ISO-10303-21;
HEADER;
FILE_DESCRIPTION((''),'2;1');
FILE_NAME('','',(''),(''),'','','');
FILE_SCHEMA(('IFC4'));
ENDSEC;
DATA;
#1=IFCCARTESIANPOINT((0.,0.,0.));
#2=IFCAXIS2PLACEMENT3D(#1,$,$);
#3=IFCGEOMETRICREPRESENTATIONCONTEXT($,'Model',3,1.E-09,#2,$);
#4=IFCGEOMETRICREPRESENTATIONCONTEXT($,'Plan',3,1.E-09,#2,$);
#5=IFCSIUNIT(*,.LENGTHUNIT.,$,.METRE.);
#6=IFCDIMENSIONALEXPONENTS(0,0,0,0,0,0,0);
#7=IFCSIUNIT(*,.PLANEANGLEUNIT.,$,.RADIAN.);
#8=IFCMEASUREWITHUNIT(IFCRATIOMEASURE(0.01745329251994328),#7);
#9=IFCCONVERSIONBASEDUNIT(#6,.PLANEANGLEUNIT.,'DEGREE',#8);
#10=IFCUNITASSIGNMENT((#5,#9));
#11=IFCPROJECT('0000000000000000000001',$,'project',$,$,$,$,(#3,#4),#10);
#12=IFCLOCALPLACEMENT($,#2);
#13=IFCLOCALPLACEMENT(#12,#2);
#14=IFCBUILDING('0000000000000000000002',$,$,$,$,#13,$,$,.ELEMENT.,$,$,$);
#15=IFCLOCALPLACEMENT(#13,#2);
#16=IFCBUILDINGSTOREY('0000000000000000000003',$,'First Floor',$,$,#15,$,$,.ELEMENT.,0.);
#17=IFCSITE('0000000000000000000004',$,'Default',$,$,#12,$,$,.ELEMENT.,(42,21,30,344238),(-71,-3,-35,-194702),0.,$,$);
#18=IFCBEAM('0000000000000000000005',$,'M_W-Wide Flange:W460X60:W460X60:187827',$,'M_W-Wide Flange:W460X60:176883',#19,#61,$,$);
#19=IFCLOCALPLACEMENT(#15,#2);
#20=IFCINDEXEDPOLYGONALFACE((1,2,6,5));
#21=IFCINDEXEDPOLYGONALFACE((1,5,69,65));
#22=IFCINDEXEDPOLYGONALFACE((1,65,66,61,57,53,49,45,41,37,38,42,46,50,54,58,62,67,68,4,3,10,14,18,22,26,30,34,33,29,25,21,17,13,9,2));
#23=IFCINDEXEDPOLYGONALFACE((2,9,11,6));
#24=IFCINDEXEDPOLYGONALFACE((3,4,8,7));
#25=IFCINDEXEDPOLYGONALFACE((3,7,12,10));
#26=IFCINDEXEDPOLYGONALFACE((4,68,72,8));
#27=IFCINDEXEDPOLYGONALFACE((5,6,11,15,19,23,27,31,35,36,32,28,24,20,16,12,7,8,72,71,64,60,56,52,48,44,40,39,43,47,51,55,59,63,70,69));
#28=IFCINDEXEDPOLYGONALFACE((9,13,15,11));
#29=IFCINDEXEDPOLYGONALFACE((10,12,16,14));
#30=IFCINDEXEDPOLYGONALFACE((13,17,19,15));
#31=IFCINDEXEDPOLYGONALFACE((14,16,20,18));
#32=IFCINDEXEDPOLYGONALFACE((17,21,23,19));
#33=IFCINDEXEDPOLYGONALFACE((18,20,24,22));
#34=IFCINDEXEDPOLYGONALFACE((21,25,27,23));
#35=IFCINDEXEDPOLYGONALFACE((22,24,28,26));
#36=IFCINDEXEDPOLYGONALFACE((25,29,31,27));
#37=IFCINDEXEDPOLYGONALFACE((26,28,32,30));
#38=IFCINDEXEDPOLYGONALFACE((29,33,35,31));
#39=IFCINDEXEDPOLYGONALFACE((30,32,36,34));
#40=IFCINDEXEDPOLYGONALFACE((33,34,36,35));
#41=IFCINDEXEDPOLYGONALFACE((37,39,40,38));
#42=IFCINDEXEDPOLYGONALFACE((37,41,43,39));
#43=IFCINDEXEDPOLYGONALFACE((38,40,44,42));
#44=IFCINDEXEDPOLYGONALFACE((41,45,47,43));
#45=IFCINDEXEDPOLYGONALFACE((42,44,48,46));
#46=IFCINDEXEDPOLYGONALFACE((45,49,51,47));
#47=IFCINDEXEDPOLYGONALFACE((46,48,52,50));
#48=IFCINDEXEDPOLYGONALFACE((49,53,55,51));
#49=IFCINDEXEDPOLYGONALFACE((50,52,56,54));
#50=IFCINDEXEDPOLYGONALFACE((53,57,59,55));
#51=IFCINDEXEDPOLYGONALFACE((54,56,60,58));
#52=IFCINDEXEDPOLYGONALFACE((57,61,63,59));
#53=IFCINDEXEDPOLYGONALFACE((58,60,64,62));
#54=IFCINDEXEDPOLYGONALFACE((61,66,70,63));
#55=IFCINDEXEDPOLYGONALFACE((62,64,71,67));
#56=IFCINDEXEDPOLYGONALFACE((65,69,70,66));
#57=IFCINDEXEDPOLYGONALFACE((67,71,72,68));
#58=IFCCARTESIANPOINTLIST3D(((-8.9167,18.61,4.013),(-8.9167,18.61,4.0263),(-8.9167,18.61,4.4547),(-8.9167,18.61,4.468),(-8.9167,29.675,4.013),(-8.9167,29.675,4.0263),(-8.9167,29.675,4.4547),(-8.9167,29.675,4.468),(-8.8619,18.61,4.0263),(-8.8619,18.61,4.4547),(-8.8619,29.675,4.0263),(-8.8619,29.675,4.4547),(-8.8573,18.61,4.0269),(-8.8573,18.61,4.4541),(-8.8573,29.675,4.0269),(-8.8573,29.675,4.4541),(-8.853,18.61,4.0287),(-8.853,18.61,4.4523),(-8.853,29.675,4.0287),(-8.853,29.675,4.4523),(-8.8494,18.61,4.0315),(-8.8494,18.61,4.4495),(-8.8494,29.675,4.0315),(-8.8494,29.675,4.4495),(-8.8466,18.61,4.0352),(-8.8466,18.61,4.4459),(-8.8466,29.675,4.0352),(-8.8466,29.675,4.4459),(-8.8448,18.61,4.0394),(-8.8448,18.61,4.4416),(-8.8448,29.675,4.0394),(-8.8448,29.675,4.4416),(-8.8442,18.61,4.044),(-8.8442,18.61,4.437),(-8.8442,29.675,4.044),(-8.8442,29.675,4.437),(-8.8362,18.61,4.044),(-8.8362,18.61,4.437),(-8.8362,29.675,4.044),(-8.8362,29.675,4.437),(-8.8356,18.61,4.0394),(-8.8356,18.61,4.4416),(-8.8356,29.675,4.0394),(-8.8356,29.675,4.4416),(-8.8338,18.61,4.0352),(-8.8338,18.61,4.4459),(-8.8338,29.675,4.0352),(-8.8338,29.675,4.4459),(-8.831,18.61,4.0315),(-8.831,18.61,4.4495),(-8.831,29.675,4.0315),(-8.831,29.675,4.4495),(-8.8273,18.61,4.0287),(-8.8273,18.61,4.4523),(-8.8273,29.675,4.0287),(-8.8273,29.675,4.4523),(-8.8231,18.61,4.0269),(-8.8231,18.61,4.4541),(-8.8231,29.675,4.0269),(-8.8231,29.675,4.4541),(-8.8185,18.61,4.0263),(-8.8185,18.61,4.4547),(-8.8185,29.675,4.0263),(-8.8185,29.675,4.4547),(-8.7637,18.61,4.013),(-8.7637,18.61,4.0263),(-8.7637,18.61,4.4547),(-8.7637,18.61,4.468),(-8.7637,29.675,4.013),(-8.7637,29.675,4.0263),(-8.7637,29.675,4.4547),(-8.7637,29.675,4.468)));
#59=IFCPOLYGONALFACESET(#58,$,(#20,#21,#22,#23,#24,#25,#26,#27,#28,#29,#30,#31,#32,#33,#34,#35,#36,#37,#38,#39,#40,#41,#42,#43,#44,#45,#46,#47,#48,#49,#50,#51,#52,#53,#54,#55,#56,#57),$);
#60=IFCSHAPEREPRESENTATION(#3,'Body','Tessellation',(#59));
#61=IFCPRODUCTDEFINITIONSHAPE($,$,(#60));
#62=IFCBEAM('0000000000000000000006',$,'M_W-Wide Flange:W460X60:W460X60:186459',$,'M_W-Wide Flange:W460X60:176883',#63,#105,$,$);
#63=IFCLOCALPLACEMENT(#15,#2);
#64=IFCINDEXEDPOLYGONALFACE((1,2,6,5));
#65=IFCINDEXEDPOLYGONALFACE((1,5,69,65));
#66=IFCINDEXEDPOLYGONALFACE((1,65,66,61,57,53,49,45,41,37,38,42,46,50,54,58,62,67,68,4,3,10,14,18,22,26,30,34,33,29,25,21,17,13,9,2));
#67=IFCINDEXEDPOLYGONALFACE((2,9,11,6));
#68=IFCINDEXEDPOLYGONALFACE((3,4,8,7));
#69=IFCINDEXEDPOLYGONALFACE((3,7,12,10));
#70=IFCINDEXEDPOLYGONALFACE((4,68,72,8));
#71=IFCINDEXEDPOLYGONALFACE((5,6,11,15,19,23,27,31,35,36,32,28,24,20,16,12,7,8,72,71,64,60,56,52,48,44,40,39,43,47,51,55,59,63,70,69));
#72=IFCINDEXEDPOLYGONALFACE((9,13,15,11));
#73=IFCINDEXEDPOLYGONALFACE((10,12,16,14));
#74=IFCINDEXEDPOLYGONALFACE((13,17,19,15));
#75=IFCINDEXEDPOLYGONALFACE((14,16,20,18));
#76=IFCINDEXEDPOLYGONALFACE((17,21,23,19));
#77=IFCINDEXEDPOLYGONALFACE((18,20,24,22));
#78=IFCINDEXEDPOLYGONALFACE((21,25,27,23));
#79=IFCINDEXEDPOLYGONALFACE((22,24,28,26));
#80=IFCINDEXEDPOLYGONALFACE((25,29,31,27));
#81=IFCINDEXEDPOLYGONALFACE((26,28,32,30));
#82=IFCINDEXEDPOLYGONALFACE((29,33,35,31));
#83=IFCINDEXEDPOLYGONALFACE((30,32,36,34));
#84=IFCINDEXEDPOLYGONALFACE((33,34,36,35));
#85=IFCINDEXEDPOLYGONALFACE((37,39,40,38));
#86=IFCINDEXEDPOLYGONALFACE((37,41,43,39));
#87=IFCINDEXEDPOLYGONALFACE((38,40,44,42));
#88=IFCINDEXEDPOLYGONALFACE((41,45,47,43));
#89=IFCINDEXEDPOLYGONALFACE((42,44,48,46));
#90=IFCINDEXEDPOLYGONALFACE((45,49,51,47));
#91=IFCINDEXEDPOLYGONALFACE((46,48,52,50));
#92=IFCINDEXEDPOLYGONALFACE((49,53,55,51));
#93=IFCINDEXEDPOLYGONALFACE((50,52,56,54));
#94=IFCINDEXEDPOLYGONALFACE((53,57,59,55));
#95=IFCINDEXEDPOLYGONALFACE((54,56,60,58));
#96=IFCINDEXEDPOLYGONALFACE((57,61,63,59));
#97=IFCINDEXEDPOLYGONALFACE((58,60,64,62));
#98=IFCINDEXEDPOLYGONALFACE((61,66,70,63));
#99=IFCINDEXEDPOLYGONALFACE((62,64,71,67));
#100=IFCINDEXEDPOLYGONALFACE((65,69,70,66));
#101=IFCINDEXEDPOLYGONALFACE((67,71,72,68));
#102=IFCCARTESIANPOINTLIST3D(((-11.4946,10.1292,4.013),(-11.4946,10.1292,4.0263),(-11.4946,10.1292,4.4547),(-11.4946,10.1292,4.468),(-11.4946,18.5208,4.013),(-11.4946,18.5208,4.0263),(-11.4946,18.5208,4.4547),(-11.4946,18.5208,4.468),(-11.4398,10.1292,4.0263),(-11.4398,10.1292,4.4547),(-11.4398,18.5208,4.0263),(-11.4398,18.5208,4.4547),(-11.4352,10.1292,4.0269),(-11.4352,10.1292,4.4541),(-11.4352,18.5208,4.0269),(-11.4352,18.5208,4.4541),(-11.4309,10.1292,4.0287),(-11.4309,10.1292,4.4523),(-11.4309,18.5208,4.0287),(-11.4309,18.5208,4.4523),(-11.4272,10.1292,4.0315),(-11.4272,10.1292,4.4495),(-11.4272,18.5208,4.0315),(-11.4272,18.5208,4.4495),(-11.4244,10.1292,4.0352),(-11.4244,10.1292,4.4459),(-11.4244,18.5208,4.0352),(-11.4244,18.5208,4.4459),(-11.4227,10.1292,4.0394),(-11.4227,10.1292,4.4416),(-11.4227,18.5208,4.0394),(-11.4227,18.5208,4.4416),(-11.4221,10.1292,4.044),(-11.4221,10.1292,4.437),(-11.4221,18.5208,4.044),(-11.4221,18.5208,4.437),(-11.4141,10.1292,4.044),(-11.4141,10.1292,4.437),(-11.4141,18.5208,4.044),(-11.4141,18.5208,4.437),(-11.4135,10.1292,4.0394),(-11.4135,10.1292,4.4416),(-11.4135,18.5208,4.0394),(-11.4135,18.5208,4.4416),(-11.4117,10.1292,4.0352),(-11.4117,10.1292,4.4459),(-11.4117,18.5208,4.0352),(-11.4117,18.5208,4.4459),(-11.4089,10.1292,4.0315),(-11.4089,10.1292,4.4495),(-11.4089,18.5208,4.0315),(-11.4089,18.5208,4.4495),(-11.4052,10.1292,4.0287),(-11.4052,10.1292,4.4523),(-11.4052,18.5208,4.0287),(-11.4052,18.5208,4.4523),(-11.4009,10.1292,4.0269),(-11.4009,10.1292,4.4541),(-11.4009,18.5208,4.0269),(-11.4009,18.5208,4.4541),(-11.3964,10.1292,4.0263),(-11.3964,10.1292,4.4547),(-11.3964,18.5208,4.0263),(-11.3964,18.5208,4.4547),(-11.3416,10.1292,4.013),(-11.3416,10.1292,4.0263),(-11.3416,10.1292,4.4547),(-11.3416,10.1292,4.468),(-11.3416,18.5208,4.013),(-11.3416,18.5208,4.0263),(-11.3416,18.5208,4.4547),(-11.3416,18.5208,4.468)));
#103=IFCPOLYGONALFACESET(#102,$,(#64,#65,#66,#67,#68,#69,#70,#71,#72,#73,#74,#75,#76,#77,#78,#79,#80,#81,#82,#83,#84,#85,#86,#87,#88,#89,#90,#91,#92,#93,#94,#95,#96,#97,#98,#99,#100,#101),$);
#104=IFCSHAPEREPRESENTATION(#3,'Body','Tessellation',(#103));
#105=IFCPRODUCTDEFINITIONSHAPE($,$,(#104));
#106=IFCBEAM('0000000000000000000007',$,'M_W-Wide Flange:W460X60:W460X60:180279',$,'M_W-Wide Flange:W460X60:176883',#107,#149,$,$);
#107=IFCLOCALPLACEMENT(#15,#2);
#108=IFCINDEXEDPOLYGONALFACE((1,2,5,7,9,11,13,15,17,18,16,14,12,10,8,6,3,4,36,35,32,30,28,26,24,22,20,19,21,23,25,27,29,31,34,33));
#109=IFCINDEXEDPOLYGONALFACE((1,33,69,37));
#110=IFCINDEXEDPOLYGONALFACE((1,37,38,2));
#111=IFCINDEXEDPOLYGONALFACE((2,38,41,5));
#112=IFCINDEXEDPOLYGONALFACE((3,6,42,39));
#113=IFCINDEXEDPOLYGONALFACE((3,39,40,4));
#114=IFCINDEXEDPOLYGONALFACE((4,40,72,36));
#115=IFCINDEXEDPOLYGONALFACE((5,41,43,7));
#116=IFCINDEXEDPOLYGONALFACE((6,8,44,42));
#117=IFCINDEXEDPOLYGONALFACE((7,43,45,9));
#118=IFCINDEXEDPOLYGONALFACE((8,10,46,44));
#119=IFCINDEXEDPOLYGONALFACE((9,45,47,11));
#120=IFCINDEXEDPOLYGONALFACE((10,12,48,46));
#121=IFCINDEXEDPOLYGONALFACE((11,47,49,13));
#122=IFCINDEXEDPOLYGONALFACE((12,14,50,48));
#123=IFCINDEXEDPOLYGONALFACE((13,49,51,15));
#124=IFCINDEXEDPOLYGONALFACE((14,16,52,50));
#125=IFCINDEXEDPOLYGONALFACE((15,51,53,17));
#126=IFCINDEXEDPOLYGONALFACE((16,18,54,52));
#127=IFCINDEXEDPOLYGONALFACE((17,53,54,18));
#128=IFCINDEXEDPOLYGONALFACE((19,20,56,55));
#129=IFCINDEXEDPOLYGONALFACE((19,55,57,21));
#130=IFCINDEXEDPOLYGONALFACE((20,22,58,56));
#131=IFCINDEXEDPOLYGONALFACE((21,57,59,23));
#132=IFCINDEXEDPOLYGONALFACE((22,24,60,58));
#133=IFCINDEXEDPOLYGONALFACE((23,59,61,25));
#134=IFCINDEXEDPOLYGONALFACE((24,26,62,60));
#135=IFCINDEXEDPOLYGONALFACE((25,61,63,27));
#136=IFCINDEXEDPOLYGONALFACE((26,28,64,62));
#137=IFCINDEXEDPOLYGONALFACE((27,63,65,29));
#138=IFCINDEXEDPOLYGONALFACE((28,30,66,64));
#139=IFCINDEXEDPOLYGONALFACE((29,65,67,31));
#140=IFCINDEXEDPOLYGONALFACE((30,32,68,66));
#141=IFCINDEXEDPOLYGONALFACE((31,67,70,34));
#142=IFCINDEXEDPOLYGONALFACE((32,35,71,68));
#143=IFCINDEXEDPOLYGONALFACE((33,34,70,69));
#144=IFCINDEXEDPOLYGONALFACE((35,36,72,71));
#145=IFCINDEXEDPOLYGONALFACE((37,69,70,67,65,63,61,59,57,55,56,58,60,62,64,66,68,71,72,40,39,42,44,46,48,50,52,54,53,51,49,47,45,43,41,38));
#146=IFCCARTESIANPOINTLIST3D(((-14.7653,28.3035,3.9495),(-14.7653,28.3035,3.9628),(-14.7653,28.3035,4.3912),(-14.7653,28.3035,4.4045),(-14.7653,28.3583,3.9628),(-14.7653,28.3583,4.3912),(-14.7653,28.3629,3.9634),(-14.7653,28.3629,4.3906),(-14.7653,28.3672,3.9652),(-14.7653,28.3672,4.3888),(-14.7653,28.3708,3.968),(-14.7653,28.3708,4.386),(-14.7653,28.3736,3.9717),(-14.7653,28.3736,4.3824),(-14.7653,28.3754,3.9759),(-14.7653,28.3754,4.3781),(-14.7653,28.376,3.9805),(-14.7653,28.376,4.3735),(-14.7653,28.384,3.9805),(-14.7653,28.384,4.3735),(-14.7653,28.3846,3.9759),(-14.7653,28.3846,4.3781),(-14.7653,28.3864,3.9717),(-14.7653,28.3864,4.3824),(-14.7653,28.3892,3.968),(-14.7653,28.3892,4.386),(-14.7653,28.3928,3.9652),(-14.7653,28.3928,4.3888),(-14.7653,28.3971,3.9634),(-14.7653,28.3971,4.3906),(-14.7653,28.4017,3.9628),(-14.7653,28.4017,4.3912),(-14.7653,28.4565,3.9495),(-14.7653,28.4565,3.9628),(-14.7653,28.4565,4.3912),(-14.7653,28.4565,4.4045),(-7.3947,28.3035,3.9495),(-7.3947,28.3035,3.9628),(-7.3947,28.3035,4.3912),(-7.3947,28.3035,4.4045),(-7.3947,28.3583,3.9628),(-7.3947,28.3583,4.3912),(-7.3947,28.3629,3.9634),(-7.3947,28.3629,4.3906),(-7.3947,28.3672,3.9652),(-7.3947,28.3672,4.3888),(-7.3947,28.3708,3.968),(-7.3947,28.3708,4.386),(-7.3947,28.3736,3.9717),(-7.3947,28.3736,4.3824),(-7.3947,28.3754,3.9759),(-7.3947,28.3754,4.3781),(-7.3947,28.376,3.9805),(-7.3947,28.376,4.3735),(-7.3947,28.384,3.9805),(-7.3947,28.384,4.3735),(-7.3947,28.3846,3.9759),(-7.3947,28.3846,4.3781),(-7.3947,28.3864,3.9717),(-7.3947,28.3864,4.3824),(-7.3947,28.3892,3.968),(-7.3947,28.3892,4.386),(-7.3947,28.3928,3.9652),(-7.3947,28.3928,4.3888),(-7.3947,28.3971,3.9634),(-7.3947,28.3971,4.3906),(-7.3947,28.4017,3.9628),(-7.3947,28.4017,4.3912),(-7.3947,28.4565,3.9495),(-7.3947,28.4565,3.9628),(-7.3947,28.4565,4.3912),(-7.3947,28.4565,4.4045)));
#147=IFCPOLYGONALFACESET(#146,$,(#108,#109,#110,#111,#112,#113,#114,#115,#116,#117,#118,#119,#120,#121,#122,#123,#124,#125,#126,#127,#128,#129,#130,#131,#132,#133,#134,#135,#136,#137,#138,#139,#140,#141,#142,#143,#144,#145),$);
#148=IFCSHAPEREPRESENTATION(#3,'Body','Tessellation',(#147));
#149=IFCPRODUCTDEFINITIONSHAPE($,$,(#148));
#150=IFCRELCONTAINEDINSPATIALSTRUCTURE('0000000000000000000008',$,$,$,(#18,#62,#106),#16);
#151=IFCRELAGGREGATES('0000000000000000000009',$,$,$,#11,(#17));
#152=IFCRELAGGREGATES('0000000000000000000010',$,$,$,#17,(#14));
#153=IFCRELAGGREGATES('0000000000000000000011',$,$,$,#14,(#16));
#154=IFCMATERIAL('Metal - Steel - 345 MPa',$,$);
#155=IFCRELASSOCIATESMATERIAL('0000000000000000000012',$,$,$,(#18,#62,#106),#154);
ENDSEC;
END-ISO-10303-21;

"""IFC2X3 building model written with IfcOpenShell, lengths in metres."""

from ifc_helpers import new_model, entity, si_unit, converted_unit, frame, frame_2d, origin, place, context, project, spatial, polyline, circle_curve, parameter, trimmed, segment, composite_curve, outline, extrude, material, element, save


model = new_model("IFC2X3")

# Units and contexts
model_context = context("Model", 3, precision=1e-09, world=origin())
plan_context = context("Plan", 3, precision=1e-09, world=origin())
ifc_project = project(units=[si_unit("LENGTHUNIT", "METRE"), converted_unit("PLANEANGLEUNIT", "DEGREE", entity("IfcRatioMeasure", 0.01745329251994328), si_unit("PLANEANGLEUNIT", "RADIAN"), dimensions=[0, 0, 0, 0, 0, 0, 0])], contexts=[model_context, plan_context])

# Site, building, storey
site_placement = place(None, origin())
site = spatial("IfcSite", under=ifc_project, at=site_placement, Name="Default", CompositionType="ELEMENT", RefLatitude=(42, 21, 30, 344238), RefLongitude=(-71, -3, -35, -194702), RefElevation=0.0)
building_placement = place(site_placement, origin())
building = spatial("IfcBuilding", under=site, at=building_placement, CompositionType="ELEMENT")
storey_placement = place(building_placement, origin())
storey = spatial("IfcBuildingStorey", under=building, at=storey_placement, Name="First Floor", CompositionType="ELEMENT", Elevation=0.0)

# Shared definitions
ifc_material = material(Name="Metal - Steel - 345 MPa")

# Beams
beam_1_placement = place(storey_placement, frame((-8.8402, 18.7626, 4.468)))
element("IfcBeam", 1, at=beam_1_placement, inside=storey, material=ifc_material, Name="M_W-Wide Flange:W460X60:W460X60:187827", ObjectType="M_W-Wide Flange:W460X60:176883", context=model_context, shape_type="SweptSolid", body=[
    extrude(outline(composite_curve([segment(polyline([(-0.0765, -0.2142), (-0.0765, -0.2275)]), True, "CONTINUOUS"), segment(polyline([(-0.0765, -0.2275), (0.0765, -0.2275)]), True, "CONTINUOUS"), segment(polyline([(0.0765, -0.2275), (0.0765, -0.2142)]), True, "CONTINUOUS"), segment(polyline([(0.0765, -0.2142), (0.0217, -0.2142)]), True, "CONTINUOUS"), segment(trimmed(circle_curve(frame_2d((0.0217, -0.1965), x_axis=(1.0, 0.0)), 0.0177), [parameter(180.0)], [parameter(270.0)], True, "PARAMETER"), False, "CONTINUOUS"), segment(polyline([(0.004, -0.1965), (0.004, 0.1965)]), True, "CONTINUOUS"), segment(trimmed(circle_curve(frame_2d((0.0217, 0.1965), x_axis=(1.0, 0.0)), 0.0177), [parameter(90.0)], [parameter(180.0)], True, "PARAMETER"), False, "CONTINUOUS"), segment(polyline([(0.0217, 0.2142), (0.0765, 0.2142)]), True, "CONTINUOUS"), segment(polyline([(0.0765, 0.2142), (0.0765, 0.2275)]), True, "CONTINUOUS"), segment(polyline([(0.0765, 0.2275), (-0.0765, 0.2275)]), True, "CONTINUOUS"), segment(polyline([(-0.0765, 0.2275), (-0.0765, 0.2142)]), True, "CONTINUOUS"), segment(polyline([(-0.0765, 0.2142), (-0.0217, 0.2142)]), True, "CONTINUOUS"), segment(trimmed(circle_curve(frame_2d((-0.0217, 0.1965), x_axis=(1.0, 0.0)), 0.0177), [parameter(360.0)], [parameter(90.0)], True, "PARAMETER"), False, "CONTINUOUS"), segment(polyline([(-0.004, 0.1965), (-0.004, -0.1965)]), True, "CONTINUOUS"), segment(trimmed(circle_curve(frame_2d((-0.0217, -0.1965), x_axis=(1.0, 0.0)), 0.0177), [parameter(270.0)], [parameter(0.0)], True, "PARAMETER"), False, "CONTINUOUS"), segment(polyline([(-0.0217, -0.2142), (-0.0765, -0.2142)]), True, "CONTINUOUS")], self_intersect=False)), frame((0.0, -0.1526, -0.2275), z_axis=(0.0, -1.0, 0.0), x_axis=(1.0, 0.0, 0.0)), (0.0, 0.0, -1.0), 11.065),
])
beam_2_placement = place(storey_placement, frame((-11.4181, 10.1909, 4.468)))
element("IfcBeam", 2, at=beam_2_placement, inside=storey, material=ifc_material, Name="M_W-Wide Flange:W460X60:W460X60:186459", ObjectType="M_W-Wide Flange:W460X60:176883", context=model_context, shape_type="SweptSolid", body=[
    extrude(outline(composite_curve([segment(polyline([(-0.0765, -0.2142), (-0.0765, -0.2275)]), True, "CONTINUOUS"), segment(polyline([(-0.0765, -0.2275), (0.0765, -0.2275)]), True, "CONTINUOUS"), segment(polyline([(0.0765, -0.2275), (0.0765, -0.2142)]), True, "CONTINUOUS"), segment(polyline([(0.0765, -0.2142), (0.0217, -0.2142)]), True, "CONTINUOUS"), segment(trimmed(circle_curve(frame_2d((0.0217, -0.1965), x_axis=(1.0, 0.0)), 0.0177), [parameter(180.0)], [parameter(270.0)], True, "PARAMETER"), False, "CONTINUOUS"), segment(polyline([(0.004, -0.1965), (0.004, 0.1965)]), True, "CONTINUOUS"), segment(trimmed(circle_curve(frame_2d((0.0217, 0.1965), x_axis=(1.0, 0.0)), 0.0177), [parameter(90.0)], [parameter(180.0)], True, "PARAMETER"), False, "CONTINUOUS"), segment(polyline([(0.0217, 0.2142), (0.0765, 0.2142)]), True, "CONTINUOUS"), segment(polyline([(0.0765, 0.2142), (0.0765, 0.2275)]), True, "CONTINUOUS"), segment(polyline([(0.0765, 0.2275), (-0.0765, 0.2275)]), True, "CONTINUOUS"), segment(polyline([(-0.0765, 0.2275), (-0.0765, 0.2142)]), True, "CONTINUOUS"), segment(polyline([(-0.0765, 0.2142), (-0.0217, 0.2142)]), True, "CONTINUOUS"), segment(trimmed(circle_curve(frame_2d((-0.0217, 0.1965), x_axis=(1.0, 0.0)), 0.0177), [parameter(360.0)], [parameter(90.0)], True, "PARAMETER"), False, "CONTINUOUS"), segment(polyline([(-0.004, 0.1965), (-0.004, -0.1965)]), True, "CONTINUOUS"), segment(trimmed(circle_curve(frame_2d((-0.0217, -0.1965), x_axis=(1.0, 0.0)), 0.0177), [parameter(270.0)], [parameter(0.0)], True, "PARAMETER"), False, "CONTINUOUS"), segment(polyline([(-0.0217, -0.2142), (-0.0765, -0.2142)]), True, "CONTINUOUS")], self_intersect=False)), frame((0.0, -0.0617, -0.2275), z_axis=(0.0, -1.0, 0.0), x_axis=(1.0, 0.0, 0.0)), (0.0, 0.0, -1.0), 8.3916),
])
beam_3_placement = place(storey_placement, frame((-7.2782, 28.38, 4.4045), z_axis=(0.0, 0.0, 1.0), x_axis=(0.0, 1.0, 0.0)))
element("IfcBeam", 3, at=beam_3_placement, inside=storey, material=ifc_material, Name="M_W-Wide Flange:W460X60:W460X60:180279", ObjectType="M_W-Wide Flange:W460X60:176883", context=model_context, shape_type="SweptSolid", body=[
    extrude(outline(composite_curve([segment(polyline([(0.2142, -0.0765), (0.2275, -0.0765)]), True, "CONTINUOUS"), segment(polyline([(0.2275, -0.0765), (0.2275, 0.0765)]), True, "CONTINUOUS"), segment(polyline([(0.2275, 0.0765), (0.2142, 0.0765)]), True, "CONTINUOUS"), segment(polyline([(0.2142, 0.0765), (0.2142, 0.0217)]), True, "CONTINUOUS"), segment(trimmed(circle_curve(frame_2d((0.1965, 0.0217), x_axis=(1.0, 0.0)), 0.0177), [parameter(270.0)], [parameter(360.0)], True, "PARAMETER"), False, "CONTINUOUS"), segment(polyline([(0.1965, 0.004), (-0.1965, 0.004)]), True, "CONTINUOUS"), segment(trimmed(circle_curve(frame_2d((-0.1965, 0.0217), x_axis=(0.0, -1.0)), 0.0177), [parameter(270.0)], [parameter(360.0)], True, "PARAMETER"), False, "CONTINUOUS"), segment(polyline([(-0.2142, 0.0217), (-0.2142, 0.0765)]), True, "CONTINUOUS"), segment(polyline([(-0.2142, 0.0765), (-0.2275, 0.0765)]), True, "CONTINUOUS"), segment(polyline([(-0.2275, 0.0765), (-0.2275, -0.0765)]), True, "CONTINUOUS"), segment(polyline([(-0.2275, -0.0765), (-0.2142, -0.0765)]), True, "CONTINUOUS"), segment(polyline([(-0.2142, -0.0765), (-0.2142, -0.0217)]), True, "CONTINUOUS"), segment(trimmed(circle_curve(frame_2d((-0.1965, -0.0217), x_axis=(-1.0, 0.0)), 0.0177), [parameter(270.0)], [parameter(360.0)], True, "PARAMETER"), False, "CONTINUOUS"), segment(polyline([(-0.1965, -0.004), (0.1965, -0.004)]), True, "CONTINUOUS"), segment(trimmed(circle_curve(frame_2d((0.1965, -0.0217), x_axis=(0.0, 1.0)), 0.0177), [parameter(270.0)], [parameter(0.0)], True, "PARAMETER"), False, "CONTINUOUS"), segment(polyline([(0.2142, -0.0217), (0.2142, -0.0765)]), True, "CONTINUOUS")], self_intersect=False)), frame((0.0, 7.4871, -0.2275), z_axis=(0.0, -1.0, 0.0), x_axis=(0.0, 0.0, -1.0)), (0.0, 0.0, 1.0), 7.3706),
])

save(model, "model.ifc")
